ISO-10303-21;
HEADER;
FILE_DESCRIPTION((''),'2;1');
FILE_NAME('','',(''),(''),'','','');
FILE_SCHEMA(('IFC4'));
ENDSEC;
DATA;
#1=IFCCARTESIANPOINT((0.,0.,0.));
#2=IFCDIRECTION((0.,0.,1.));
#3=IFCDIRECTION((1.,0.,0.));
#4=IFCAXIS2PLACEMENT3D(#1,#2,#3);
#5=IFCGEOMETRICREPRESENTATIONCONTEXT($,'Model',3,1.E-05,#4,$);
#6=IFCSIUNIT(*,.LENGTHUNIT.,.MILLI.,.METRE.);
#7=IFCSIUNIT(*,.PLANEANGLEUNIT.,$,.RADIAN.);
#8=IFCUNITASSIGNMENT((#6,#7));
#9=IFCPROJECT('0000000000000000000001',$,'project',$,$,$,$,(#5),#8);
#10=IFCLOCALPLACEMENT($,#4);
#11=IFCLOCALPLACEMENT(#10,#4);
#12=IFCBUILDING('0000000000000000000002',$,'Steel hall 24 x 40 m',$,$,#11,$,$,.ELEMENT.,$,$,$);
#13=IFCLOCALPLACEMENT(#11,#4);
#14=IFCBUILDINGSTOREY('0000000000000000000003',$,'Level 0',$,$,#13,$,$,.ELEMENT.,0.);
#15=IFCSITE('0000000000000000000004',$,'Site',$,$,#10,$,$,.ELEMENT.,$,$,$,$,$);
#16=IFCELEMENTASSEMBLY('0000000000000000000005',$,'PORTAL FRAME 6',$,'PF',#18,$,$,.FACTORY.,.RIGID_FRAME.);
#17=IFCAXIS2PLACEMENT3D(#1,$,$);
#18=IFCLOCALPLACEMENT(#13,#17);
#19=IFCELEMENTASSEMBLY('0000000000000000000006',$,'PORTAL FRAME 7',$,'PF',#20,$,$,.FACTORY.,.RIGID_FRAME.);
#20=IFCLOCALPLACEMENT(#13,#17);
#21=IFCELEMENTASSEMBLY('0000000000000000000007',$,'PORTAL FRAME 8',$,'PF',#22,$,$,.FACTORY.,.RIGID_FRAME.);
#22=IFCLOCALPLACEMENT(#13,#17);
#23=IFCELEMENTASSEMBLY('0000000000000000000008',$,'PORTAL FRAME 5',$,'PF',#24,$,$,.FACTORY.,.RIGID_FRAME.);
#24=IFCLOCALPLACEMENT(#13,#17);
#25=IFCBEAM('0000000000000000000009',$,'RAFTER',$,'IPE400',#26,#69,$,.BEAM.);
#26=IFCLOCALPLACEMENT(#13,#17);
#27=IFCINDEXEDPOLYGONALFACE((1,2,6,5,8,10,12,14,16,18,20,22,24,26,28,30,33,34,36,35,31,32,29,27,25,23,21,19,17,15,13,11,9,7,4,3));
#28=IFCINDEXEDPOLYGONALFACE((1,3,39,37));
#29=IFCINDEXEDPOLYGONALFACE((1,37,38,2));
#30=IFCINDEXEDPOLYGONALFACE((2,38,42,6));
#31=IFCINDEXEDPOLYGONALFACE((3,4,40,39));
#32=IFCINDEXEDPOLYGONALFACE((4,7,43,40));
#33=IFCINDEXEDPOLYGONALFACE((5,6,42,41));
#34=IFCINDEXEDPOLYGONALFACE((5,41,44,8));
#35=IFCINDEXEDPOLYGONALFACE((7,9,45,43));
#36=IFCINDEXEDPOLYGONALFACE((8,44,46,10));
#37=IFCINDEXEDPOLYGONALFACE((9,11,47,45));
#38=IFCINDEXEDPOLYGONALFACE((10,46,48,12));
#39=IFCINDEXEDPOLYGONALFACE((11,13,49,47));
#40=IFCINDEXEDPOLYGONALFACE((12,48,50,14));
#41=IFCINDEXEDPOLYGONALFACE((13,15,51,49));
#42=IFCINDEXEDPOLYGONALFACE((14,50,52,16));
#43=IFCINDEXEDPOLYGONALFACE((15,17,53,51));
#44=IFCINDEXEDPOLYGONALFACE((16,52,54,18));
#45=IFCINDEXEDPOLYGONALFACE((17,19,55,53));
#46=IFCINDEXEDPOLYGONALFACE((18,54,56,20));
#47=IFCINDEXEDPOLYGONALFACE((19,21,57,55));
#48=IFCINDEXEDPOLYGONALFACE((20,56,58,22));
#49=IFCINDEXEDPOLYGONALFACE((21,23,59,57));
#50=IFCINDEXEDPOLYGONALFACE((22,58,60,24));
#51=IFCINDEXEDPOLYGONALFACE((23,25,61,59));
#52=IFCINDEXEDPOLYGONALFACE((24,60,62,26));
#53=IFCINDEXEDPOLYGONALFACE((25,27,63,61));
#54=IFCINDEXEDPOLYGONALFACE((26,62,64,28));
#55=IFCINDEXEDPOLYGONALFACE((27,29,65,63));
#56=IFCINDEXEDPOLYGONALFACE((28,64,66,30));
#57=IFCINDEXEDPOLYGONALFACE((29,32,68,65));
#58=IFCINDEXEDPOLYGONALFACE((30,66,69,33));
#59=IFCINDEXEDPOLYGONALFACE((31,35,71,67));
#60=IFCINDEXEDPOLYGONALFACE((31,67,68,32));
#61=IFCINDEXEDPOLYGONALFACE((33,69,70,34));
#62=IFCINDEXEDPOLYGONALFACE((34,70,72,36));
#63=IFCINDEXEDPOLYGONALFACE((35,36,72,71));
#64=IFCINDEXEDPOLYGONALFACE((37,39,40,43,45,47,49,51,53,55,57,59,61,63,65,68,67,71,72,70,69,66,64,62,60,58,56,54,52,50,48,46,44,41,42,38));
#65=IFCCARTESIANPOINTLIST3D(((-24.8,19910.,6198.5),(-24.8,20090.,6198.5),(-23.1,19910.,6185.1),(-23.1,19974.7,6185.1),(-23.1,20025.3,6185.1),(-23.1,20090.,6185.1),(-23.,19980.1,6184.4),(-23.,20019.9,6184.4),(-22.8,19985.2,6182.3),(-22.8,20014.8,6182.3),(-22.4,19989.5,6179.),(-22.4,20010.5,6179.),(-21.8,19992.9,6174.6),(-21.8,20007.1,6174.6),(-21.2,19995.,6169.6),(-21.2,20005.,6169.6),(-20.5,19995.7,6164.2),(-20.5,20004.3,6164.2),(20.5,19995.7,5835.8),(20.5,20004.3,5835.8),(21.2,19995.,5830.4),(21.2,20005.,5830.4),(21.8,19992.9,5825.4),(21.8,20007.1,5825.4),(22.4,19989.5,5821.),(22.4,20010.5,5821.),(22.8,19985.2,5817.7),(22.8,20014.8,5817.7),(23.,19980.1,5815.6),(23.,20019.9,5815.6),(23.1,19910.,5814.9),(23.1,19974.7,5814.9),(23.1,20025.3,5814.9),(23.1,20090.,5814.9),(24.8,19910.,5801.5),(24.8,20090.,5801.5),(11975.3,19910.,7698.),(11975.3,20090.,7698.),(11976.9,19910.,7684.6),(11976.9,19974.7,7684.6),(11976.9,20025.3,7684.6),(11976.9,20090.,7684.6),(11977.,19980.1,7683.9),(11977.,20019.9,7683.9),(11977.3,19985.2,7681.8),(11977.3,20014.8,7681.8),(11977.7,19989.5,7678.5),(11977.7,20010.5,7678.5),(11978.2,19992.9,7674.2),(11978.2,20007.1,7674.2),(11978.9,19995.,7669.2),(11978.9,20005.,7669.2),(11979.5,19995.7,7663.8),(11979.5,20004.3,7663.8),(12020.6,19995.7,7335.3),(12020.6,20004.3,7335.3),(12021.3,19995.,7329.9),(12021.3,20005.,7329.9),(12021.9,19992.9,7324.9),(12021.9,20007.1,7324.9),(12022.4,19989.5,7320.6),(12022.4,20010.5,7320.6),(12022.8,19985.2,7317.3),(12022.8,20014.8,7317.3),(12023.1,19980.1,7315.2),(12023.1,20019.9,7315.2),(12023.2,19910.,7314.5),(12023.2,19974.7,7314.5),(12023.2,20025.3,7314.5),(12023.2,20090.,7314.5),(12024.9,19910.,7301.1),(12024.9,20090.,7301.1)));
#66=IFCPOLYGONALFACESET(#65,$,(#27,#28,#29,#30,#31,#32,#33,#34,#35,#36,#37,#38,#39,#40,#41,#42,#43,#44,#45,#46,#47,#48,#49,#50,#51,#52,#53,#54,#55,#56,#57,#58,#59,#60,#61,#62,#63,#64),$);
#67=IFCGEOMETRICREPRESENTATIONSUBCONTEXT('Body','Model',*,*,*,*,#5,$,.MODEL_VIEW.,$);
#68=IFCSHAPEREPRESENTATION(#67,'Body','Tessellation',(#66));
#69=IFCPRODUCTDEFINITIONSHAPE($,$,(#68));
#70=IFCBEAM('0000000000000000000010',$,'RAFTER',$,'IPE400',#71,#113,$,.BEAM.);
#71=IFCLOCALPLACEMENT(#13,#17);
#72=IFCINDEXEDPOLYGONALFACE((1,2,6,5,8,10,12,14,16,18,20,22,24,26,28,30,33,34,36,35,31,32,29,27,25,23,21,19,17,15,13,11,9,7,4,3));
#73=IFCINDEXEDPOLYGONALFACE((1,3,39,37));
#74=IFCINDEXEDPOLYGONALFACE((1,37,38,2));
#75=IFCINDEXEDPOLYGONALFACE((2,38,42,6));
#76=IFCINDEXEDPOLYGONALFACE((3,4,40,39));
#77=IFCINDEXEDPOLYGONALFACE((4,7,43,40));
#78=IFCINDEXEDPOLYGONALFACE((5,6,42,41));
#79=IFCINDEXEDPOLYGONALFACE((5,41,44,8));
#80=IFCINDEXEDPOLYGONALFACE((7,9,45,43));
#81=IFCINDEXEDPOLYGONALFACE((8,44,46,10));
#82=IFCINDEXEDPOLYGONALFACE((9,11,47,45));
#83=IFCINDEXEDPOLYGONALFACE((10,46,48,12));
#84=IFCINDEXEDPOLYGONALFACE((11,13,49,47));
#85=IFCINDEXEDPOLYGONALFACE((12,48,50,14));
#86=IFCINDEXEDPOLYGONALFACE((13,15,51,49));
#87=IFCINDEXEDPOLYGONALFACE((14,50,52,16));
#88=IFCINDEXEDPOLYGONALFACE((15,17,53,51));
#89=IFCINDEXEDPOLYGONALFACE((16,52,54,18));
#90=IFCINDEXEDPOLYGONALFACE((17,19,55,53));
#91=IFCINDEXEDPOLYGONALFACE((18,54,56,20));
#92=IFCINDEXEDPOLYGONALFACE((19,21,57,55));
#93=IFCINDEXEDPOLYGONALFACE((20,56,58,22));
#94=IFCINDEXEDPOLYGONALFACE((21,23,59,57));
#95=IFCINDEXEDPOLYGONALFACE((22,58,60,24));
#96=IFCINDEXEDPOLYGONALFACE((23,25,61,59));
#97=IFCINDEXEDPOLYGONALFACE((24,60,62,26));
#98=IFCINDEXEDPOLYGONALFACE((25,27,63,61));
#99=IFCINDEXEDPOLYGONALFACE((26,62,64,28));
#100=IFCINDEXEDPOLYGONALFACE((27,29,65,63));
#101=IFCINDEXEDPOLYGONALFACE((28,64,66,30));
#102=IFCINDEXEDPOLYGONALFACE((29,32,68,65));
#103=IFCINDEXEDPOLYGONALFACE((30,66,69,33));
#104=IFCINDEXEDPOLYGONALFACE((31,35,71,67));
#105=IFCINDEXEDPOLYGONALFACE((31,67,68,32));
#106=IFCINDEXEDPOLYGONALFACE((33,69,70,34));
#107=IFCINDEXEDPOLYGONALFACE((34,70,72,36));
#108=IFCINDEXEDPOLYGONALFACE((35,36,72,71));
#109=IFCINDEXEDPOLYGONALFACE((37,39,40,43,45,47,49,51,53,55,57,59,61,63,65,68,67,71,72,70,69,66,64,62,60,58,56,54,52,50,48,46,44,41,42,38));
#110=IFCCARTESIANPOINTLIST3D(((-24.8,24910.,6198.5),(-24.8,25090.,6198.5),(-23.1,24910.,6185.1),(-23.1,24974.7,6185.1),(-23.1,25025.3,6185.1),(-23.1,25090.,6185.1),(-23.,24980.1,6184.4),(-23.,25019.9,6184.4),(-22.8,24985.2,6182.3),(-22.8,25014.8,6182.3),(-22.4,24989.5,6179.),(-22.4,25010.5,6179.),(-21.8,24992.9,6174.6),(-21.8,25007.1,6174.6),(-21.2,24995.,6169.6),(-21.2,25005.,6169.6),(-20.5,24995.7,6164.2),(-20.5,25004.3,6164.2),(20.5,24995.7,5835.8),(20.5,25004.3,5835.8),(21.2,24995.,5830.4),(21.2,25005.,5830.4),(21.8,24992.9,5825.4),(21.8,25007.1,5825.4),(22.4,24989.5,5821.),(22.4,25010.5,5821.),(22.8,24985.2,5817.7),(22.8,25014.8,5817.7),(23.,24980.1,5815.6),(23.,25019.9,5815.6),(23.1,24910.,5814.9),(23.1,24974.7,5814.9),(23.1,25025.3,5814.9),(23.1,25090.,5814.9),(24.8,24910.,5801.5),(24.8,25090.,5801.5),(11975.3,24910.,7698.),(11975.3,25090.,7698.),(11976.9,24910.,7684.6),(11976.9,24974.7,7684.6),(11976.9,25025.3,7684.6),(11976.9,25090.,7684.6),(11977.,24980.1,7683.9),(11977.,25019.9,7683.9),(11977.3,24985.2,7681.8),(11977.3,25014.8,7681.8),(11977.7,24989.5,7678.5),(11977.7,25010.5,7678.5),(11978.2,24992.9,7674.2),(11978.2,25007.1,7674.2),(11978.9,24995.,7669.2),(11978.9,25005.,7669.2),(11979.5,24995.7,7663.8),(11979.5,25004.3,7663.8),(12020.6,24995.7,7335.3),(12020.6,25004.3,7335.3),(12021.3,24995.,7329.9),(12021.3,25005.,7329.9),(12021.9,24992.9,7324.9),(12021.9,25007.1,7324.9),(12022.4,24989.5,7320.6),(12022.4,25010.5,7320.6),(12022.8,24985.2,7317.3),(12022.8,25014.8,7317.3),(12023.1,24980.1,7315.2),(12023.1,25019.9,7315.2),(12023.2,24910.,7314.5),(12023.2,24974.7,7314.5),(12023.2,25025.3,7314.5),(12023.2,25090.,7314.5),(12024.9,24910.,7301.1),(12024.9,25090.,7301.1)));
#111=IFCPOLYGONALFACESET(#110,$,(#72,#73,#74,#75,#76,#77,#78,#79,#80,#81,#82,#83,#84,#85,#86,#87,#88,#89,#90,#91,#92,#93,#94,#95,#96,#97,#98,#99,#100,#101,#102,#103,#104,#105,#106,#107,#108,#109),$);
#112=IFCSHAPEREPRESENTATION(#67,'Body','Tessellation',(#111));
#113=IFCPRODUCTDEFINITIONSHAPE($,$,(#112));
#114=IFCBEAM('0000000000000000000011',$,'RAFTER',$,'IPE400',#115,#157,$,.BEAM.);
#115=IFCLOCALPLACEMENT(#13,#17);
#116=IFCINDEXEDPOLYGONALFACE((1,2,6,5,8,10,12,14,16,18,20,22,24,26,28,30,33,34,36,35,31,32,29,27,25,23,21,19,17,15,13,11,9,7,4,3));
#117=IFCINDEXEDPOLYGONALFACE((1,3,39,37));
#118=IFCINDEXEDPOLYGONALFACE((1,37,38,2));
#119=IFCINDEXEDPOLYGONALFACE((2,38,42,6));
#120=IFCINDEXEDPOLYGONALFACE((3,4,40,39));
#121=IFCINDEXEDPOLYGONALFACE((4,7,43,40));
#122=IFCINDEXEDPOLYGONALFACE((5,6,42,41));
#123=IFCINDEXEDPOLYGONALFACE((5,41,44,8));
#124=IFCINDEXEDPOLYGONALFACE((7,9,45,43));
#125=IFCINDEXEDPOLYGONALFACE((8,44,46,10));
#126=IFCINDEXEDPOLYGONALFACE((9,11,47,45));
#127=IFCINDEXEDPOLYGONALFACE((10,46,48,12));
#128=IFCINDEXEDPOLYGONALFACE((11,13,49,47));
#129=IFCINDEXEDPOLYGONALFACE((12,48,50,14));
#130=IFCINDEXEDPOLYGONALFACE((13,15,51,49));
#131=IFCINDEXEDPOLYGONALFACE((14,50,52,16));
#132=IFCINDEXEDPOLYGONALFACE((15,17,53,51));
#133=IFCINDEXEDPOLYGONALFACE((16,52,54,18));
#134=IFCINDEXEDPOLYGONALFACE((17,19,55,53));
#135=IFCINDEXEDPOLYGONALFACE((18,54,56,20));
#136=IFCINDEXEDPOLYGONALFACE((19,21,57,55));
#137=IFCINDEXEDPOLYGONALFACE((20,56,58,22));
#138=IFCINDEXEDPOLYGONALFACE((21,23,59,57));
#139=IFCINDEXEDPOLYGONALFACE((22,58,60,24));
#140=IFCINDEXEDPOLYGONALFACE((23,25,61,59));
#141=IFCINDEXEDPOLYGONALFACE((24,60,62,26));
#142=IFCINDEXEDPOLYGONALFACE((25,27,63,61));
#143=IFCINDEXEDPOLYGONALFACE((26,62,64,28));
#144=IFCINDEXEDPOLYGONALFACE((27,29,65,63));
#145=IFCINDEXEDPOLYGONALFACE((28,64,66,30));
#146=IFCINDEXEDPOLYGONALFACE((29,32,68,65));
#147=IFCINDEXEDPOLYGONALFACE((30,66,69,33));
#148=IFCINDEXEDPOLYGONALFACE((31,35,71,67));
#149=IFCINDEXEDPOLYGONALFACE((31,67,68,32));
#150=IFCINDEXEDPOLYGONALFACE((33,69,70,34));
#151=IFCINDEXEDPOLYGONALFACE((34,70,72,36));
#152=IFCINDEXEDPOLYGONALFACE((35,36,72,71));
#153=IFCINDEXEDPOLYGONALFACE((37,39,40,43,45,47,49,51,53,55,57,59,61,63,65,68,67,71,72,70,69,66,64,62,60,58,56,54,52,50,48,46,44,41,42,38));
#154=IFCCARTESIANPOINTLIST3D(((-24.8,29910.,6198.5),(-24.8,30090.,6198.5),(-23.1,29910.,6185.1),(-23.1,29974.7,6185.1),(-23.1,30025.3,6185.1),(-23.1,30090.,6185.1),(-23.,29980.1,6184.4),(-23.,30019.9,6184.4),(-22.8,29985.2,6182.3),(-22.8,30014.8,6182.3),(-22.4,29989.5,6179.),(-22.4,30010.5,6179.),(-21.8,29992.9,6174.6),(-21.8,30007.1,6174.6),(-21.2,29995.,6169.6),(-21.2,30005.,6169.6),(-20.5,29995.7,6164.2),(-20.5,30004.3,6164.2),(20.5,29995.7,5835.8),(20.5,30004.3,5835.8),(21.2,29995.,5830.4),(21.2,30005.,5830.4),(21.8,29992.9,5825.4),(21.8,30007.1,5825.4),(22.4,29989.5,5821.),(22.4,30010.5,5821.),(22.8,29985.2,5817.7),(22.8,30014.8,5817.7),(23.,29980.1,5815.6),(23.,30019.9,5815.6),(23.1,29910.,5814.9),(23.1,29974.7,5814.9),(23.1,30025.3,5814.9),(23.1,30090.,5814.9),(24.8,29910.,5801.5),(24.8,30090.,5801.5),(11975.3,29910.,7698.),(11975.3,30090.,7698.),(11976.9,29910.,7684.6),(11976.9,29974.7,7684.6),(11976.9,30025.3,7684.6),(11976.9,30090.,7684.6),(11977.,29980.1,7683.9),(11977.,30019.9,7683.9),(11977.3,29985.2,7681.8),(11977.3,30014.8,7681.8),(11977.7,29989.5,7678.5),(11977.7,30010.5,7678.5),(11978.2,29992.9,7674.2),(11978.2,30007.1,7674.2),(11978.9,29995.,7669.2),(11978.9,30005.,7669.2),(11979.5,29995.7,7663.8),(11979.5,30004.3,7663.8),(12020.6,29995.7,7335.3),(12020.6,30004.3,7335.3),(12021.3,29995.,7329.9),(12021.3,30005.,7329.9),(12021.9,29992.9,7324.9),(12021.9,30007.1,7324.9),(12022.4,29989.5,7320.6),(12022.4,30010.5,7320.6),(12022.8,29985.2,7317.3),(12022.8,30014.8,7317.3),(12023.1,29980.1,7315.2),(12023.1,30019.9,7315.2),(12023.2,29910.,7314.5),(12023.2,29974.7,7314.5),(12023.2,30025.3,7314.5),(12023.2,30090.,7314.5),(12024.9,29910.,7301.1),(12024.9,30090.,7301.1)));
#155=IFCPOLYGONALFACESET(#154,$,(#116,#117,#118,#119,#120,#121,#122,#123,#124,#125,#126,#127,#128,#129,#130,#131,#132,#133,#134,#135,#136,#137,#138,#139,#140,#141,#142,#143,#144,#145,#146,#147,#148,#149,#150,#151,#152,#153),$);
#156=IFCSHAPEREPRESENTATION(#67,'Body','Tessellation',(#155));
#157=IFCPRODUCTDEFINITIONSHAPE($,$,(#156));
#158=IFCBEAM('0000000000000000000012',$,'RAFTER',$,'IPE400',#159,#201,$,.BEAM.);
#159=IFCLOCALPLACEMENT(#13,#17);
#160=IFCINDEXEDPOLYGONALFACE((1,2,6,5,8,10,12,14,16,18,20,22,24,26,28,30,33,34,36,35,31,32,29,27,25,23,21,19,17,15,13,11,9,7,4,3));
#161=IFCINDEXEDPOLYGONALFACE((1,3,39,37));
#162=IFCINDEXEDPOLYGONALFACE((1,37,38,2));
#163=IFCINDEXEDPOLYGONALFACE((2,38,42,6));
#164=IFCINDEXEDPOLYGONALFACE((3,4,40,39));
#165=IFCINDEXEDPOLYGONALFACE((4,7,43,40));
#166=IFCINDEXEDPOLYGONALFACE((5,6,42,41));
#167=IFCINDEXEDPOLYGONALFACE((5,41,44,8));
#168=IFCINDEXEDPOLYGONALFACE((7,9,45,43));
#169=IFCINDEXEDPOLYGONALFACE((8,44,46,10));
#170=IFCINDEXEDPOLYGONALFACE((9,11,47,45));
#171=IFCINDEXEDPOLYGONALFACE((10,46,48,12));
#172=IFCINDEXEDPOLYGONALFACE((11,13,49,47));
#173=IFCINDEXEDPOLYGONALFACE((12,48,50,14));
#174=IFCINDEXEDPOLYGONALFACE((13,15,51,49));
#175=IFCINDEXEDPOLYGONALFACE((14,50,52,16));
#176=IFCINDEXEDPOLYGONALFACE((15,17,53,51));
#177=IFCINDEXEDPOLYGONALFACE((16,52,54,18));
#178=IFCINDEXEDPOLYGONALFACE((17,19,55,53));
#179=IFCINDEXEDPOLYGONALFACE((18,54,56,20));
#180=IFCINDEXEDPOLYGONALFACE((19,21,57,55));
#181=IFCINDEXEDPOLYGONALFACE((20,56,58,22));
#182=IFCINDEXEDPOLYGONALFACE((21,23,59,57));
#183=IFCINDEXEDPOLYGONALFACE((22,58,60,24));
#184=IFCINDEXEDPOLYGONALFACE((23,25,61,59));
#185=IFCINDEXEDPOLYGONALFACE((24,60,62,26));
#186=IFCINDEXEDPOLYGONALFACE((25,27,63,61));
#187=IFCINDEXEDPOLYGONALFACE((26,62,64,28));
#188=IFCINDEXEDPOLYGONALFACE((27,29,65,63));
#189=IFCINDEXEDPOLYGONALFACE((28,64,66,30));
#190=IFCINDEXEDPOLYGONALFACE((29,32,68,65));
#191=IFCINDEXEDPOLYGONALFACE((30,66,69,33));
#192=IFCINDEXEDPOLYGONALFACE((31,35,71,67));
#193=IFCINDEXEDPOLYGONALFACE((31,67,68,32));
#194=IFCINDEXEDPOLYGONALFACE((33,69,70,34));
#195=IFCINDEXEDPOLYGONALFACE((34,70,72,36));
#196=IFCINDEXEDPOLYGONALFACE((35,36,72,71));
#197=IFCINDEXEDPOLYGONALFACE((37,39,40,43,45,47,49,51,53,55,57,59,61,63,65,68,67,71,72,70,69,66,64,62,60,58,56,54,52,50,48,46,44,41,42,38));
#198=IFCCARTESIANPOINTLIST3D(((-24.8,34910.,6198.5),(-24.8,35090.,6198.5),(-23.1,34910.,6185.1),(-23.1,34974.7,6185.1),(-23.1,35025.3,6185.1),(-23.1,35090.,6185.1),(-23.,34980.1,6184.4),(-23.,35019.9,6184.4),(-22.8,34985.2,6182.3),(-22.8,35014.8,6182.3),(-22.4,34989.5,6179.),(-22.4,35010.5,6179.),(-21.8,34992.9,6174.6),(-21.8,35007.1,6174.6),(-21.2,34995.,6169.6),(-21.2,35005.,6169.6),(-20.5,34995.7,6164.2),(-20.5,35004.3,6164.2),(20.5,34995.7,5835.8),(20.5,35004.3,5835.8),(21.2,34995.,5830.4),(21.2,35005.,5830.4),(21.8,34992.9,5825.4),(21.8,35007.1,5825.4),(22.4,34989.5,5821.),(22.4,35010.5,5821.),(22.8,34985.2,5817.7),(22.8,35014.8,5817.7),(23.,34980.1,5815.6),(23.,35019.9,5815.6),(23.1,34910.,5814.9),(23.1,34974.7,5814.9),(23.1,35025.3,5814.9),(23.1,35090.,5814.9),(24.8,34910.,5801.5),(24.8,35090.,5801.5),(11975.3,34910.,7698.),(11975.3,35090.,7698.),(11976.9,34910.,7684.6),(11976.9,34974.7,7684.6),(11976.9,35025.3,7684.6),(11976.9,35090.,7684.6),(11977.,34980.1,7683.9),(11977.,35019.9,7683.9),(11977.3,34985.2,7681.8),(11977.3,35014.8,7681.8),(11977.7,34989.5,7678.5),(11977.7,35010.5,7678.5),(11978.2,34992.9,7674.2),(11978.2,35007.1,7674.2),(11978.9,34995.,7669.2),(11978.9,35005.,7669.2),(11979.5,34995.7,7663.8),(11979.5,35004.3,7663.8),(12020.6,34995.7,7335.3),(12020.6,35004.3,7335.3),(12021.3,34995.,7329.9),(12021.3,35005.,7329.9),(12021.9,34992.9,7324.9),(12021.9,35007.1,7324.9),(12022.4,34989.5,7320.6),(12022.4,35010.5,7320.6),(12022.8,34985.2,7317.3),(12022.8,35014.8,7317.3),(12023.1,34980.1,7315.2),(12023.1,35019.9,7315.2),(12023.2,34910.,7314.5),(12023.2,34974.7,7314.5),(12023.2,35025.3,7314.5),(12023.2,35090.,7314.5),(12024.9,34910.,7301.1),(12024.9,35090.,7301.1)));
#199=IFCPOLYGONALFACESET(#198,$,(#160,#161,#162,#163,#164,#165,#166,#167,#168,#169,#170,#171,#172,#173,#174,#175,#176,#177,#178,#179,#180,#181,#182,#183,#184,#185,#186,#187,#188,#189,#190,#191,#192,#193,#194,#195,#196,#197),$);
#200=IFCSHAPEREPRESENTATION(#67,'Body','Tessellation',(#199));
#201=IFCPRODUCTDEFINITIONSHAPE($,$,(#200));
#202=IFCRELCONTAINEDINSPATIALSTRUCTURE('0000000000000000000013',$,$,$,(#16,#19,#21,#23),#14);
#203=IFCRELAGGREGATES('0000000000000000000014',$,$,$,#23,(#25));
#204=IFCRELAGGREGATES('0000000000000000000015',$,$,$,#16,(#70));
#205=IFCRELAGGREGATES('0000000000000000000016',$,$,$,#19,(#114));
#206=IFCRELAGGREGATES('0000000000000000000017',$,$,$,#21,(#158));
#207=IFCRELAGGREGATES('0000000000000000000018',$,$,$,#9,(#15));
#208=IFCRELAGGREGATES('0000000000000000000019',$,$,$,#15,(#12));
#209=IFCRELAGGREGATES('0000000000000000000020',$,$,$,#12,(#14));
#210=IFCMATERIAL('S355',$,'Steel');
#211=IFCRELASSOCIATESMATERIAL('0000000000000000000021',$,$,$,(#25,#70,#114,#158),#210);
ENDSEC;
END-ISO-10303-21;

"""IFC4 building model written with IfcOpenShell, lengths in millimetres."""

from ifc_helpers import new_model, si_unit, frame, origin_with_axes, place, context, subcontext, project, spatial, i_section, extrude, material, element, aggregate, save


model = new_model("IFC4")

# Units and contexts
model_context = context("Model", 3, precision=1e-05, world=origin_with_axes())
body_context = subcontext(model_context, "Body", "Model", "MODEL_VIEW")
ifc_project = project(units=[si_unit("LENGTHUNIT", "METRE", prefix="MILLI"), si_unit("PLANEANGLEUNIT", "RADIAN")], contexts=[model_context])

# Site, building, storey
site_placement = place(None, origin_with_axes())
site = spatial("IfcSite", under=ifc_project, at=site_placement, Name="Site", CompositionType="ELEMENT")
building_placement = place(site_placement, origin_with_axes())
building = spatial("IfcBuilding", under=site, at=building_placement, Name="Steel hall 24 x 40 m", CompositionType="ELEMENT")
storey_placement = place(building_placement, origin_with_axes())
storey = spatial("IfcBuildingStorey", under=building, at=storey_placement, Name="Level 0", CompositionType="ELEMENT", Elevation=0.0)

# Element assemblies
assembly_1_placement = place(storey_placement, frame((0.0, 25000.0, 0.0), z_axis=(0.0, 0.0, 1.0), x_axis=(1.0, 0.0, 0.0)))
assembly_1 = element("IfcElementAssembly", 1, at=assembly_1_placement, inside=storey, Name="PORTAL FRAME 6", ObjectType="PF", AssemblyPlace="FACTORY", PredefinedType="RIGID_FRAME")
ifc_material = material(Name="S355", Category="Steel")
assembly_2_placement = place(storey_placement, frame((0.0, 30000.0, 0.0), z_axis=(0.0, 0.0, 1.0), x_axis=(1.0, 0.0, 0.0)))
assembly_2 = element("IfcElementAssembly", 2, at=assembly_2_placement, inside=storey, Name="PORTAL FRAME 7", ObjectType="PF", AssemblyPlace="FACTORY", PredefinedType="RIGID_FRAME")
assembly_3_placement = place(storey_placement, frame((0.0, 35000.0, 0.0), z_axis=(0.0, 0.0, 1.0), x_axis=(1.0, 0.0, 0.0)))
assembly_3 = element("IfcElementAssembly", 3, at=assembly_3_placement, inside=storey, Name="PORTAL FRAME 8", ObjectType="PF", AssemblyPlace="FACTORY", PredefinedType="RIGID_FRAME")

# Element assembly, beam
assembly_4_placement = place(storey_placement, frame((0.0, 20000.0, 0.0), z_axis=(0.0, 0.0, 1.0), x_axis=(1.0, 0.0, 0.0)))
assembly_4 = element("IfcElementAssembly", 4, at=assembly_4_placement, inside=storey, Name="PORTAL FRAME 5", ObjectType="PF", AssemblyPlace="FACTORY", PredefinedType="RIGID_FRAME")
beam_1_placement = place(storey_placement, frame((0.0, 20000.0, 6000.0), z_axis=(0.9923, 0.0, 0.124), x_axis=(0.0, 1.0, 0.0)))
beam_1 = element("IfcBeam", 5, at=beam_1_placement, material=ifc_material, Name="RAFTER", ObjectType="IPE400", PredefinedType="BEAM", context=body_context, shape_type="SweptSolid", body=[
    extrude(i_section(OverallWidth=180.0, OverallDepth=400.0, WebThickness=8.6, FlangeThickness=13.5, FilletRadius=21.0), origin_with_axes(), (0.0, 0.0, 1.0), 12093.4),
])
aggregate(assembly_4, [beam_1])

# Beams
beam_2_placement = place(storey_placement, frame((0.0, 25000.0, 6000.0), z_axis=(0.9923, 0.0, 0.124), x_axis=(0.0, 1.0, 0.0)))
beam_2 = element("IfcBeam", 6, at=beam_2_placement, material=ifc_material, Name="RAFTER", ObjectType="IPE400", PredefinedType="BEAM", context=body_context, shape_type="SweptSolid", body=[
    extrude(i_section(OverallWidth=180.0, OverallDepth=400.0, WebThickness=8.6, FlangeThickness=13.5, FilletRadius=21.0), origin_with_axes(), (0.0, 0.0, 1.0), 12093.4),
])
beam_3_placement = place(storey_placement, frame((0.0, 30000.0, 6000.0), z_axis=(0.9923, 0.0, 0.124), x_axis=(0.0, 1.0, 0.0)))
beam_3 = element("IfcBeam", 7, at=beam_3_placement, material=ifc_material, Name="RAFTER", ObjectType="IPE400", PredefinedType="BEAM", context=body_context, shape_type="SweptSolid", body=[
    extrude(i_section(OverallWidth=180.0, OverallDepth=400.0, WebThickness=8.6, FlangeThickness=13.5, FilletRadius=21.0), origin_with_axes(), (0.0, 0.0, 1.0), 12093.4),
])
beam_4_placement = place(storey_placement, frame((0.0, 35000.0, 6000.0), z_axis=(0.9923, 0.0, 0.124), x_axis=(0.0, 1.0, 0.0)))
beam_4 = element("IfcBeam", 8, at=beam_4_placement, material=ifc_material, Name="RAFTER", ObjectType="IPE400", PredefinedType="BEAM", context=body_context, shape_type="SweptSolid", body=[
    extrude(i_section(OverallWidth=180.0, OverallDepth=400.0, WebThickness=8.6, FlangeThickness=13.5, FilletRadius=21.0), origin_with_axes(), (0.0, 0.0, 1.0), 12093.4),
])

aggregate(assembly_1, [beam_2])
aggregate(assembly_2, [beam_3])
aggregate(assembly_3, [beam_4])

save(model, "model.ifc")
